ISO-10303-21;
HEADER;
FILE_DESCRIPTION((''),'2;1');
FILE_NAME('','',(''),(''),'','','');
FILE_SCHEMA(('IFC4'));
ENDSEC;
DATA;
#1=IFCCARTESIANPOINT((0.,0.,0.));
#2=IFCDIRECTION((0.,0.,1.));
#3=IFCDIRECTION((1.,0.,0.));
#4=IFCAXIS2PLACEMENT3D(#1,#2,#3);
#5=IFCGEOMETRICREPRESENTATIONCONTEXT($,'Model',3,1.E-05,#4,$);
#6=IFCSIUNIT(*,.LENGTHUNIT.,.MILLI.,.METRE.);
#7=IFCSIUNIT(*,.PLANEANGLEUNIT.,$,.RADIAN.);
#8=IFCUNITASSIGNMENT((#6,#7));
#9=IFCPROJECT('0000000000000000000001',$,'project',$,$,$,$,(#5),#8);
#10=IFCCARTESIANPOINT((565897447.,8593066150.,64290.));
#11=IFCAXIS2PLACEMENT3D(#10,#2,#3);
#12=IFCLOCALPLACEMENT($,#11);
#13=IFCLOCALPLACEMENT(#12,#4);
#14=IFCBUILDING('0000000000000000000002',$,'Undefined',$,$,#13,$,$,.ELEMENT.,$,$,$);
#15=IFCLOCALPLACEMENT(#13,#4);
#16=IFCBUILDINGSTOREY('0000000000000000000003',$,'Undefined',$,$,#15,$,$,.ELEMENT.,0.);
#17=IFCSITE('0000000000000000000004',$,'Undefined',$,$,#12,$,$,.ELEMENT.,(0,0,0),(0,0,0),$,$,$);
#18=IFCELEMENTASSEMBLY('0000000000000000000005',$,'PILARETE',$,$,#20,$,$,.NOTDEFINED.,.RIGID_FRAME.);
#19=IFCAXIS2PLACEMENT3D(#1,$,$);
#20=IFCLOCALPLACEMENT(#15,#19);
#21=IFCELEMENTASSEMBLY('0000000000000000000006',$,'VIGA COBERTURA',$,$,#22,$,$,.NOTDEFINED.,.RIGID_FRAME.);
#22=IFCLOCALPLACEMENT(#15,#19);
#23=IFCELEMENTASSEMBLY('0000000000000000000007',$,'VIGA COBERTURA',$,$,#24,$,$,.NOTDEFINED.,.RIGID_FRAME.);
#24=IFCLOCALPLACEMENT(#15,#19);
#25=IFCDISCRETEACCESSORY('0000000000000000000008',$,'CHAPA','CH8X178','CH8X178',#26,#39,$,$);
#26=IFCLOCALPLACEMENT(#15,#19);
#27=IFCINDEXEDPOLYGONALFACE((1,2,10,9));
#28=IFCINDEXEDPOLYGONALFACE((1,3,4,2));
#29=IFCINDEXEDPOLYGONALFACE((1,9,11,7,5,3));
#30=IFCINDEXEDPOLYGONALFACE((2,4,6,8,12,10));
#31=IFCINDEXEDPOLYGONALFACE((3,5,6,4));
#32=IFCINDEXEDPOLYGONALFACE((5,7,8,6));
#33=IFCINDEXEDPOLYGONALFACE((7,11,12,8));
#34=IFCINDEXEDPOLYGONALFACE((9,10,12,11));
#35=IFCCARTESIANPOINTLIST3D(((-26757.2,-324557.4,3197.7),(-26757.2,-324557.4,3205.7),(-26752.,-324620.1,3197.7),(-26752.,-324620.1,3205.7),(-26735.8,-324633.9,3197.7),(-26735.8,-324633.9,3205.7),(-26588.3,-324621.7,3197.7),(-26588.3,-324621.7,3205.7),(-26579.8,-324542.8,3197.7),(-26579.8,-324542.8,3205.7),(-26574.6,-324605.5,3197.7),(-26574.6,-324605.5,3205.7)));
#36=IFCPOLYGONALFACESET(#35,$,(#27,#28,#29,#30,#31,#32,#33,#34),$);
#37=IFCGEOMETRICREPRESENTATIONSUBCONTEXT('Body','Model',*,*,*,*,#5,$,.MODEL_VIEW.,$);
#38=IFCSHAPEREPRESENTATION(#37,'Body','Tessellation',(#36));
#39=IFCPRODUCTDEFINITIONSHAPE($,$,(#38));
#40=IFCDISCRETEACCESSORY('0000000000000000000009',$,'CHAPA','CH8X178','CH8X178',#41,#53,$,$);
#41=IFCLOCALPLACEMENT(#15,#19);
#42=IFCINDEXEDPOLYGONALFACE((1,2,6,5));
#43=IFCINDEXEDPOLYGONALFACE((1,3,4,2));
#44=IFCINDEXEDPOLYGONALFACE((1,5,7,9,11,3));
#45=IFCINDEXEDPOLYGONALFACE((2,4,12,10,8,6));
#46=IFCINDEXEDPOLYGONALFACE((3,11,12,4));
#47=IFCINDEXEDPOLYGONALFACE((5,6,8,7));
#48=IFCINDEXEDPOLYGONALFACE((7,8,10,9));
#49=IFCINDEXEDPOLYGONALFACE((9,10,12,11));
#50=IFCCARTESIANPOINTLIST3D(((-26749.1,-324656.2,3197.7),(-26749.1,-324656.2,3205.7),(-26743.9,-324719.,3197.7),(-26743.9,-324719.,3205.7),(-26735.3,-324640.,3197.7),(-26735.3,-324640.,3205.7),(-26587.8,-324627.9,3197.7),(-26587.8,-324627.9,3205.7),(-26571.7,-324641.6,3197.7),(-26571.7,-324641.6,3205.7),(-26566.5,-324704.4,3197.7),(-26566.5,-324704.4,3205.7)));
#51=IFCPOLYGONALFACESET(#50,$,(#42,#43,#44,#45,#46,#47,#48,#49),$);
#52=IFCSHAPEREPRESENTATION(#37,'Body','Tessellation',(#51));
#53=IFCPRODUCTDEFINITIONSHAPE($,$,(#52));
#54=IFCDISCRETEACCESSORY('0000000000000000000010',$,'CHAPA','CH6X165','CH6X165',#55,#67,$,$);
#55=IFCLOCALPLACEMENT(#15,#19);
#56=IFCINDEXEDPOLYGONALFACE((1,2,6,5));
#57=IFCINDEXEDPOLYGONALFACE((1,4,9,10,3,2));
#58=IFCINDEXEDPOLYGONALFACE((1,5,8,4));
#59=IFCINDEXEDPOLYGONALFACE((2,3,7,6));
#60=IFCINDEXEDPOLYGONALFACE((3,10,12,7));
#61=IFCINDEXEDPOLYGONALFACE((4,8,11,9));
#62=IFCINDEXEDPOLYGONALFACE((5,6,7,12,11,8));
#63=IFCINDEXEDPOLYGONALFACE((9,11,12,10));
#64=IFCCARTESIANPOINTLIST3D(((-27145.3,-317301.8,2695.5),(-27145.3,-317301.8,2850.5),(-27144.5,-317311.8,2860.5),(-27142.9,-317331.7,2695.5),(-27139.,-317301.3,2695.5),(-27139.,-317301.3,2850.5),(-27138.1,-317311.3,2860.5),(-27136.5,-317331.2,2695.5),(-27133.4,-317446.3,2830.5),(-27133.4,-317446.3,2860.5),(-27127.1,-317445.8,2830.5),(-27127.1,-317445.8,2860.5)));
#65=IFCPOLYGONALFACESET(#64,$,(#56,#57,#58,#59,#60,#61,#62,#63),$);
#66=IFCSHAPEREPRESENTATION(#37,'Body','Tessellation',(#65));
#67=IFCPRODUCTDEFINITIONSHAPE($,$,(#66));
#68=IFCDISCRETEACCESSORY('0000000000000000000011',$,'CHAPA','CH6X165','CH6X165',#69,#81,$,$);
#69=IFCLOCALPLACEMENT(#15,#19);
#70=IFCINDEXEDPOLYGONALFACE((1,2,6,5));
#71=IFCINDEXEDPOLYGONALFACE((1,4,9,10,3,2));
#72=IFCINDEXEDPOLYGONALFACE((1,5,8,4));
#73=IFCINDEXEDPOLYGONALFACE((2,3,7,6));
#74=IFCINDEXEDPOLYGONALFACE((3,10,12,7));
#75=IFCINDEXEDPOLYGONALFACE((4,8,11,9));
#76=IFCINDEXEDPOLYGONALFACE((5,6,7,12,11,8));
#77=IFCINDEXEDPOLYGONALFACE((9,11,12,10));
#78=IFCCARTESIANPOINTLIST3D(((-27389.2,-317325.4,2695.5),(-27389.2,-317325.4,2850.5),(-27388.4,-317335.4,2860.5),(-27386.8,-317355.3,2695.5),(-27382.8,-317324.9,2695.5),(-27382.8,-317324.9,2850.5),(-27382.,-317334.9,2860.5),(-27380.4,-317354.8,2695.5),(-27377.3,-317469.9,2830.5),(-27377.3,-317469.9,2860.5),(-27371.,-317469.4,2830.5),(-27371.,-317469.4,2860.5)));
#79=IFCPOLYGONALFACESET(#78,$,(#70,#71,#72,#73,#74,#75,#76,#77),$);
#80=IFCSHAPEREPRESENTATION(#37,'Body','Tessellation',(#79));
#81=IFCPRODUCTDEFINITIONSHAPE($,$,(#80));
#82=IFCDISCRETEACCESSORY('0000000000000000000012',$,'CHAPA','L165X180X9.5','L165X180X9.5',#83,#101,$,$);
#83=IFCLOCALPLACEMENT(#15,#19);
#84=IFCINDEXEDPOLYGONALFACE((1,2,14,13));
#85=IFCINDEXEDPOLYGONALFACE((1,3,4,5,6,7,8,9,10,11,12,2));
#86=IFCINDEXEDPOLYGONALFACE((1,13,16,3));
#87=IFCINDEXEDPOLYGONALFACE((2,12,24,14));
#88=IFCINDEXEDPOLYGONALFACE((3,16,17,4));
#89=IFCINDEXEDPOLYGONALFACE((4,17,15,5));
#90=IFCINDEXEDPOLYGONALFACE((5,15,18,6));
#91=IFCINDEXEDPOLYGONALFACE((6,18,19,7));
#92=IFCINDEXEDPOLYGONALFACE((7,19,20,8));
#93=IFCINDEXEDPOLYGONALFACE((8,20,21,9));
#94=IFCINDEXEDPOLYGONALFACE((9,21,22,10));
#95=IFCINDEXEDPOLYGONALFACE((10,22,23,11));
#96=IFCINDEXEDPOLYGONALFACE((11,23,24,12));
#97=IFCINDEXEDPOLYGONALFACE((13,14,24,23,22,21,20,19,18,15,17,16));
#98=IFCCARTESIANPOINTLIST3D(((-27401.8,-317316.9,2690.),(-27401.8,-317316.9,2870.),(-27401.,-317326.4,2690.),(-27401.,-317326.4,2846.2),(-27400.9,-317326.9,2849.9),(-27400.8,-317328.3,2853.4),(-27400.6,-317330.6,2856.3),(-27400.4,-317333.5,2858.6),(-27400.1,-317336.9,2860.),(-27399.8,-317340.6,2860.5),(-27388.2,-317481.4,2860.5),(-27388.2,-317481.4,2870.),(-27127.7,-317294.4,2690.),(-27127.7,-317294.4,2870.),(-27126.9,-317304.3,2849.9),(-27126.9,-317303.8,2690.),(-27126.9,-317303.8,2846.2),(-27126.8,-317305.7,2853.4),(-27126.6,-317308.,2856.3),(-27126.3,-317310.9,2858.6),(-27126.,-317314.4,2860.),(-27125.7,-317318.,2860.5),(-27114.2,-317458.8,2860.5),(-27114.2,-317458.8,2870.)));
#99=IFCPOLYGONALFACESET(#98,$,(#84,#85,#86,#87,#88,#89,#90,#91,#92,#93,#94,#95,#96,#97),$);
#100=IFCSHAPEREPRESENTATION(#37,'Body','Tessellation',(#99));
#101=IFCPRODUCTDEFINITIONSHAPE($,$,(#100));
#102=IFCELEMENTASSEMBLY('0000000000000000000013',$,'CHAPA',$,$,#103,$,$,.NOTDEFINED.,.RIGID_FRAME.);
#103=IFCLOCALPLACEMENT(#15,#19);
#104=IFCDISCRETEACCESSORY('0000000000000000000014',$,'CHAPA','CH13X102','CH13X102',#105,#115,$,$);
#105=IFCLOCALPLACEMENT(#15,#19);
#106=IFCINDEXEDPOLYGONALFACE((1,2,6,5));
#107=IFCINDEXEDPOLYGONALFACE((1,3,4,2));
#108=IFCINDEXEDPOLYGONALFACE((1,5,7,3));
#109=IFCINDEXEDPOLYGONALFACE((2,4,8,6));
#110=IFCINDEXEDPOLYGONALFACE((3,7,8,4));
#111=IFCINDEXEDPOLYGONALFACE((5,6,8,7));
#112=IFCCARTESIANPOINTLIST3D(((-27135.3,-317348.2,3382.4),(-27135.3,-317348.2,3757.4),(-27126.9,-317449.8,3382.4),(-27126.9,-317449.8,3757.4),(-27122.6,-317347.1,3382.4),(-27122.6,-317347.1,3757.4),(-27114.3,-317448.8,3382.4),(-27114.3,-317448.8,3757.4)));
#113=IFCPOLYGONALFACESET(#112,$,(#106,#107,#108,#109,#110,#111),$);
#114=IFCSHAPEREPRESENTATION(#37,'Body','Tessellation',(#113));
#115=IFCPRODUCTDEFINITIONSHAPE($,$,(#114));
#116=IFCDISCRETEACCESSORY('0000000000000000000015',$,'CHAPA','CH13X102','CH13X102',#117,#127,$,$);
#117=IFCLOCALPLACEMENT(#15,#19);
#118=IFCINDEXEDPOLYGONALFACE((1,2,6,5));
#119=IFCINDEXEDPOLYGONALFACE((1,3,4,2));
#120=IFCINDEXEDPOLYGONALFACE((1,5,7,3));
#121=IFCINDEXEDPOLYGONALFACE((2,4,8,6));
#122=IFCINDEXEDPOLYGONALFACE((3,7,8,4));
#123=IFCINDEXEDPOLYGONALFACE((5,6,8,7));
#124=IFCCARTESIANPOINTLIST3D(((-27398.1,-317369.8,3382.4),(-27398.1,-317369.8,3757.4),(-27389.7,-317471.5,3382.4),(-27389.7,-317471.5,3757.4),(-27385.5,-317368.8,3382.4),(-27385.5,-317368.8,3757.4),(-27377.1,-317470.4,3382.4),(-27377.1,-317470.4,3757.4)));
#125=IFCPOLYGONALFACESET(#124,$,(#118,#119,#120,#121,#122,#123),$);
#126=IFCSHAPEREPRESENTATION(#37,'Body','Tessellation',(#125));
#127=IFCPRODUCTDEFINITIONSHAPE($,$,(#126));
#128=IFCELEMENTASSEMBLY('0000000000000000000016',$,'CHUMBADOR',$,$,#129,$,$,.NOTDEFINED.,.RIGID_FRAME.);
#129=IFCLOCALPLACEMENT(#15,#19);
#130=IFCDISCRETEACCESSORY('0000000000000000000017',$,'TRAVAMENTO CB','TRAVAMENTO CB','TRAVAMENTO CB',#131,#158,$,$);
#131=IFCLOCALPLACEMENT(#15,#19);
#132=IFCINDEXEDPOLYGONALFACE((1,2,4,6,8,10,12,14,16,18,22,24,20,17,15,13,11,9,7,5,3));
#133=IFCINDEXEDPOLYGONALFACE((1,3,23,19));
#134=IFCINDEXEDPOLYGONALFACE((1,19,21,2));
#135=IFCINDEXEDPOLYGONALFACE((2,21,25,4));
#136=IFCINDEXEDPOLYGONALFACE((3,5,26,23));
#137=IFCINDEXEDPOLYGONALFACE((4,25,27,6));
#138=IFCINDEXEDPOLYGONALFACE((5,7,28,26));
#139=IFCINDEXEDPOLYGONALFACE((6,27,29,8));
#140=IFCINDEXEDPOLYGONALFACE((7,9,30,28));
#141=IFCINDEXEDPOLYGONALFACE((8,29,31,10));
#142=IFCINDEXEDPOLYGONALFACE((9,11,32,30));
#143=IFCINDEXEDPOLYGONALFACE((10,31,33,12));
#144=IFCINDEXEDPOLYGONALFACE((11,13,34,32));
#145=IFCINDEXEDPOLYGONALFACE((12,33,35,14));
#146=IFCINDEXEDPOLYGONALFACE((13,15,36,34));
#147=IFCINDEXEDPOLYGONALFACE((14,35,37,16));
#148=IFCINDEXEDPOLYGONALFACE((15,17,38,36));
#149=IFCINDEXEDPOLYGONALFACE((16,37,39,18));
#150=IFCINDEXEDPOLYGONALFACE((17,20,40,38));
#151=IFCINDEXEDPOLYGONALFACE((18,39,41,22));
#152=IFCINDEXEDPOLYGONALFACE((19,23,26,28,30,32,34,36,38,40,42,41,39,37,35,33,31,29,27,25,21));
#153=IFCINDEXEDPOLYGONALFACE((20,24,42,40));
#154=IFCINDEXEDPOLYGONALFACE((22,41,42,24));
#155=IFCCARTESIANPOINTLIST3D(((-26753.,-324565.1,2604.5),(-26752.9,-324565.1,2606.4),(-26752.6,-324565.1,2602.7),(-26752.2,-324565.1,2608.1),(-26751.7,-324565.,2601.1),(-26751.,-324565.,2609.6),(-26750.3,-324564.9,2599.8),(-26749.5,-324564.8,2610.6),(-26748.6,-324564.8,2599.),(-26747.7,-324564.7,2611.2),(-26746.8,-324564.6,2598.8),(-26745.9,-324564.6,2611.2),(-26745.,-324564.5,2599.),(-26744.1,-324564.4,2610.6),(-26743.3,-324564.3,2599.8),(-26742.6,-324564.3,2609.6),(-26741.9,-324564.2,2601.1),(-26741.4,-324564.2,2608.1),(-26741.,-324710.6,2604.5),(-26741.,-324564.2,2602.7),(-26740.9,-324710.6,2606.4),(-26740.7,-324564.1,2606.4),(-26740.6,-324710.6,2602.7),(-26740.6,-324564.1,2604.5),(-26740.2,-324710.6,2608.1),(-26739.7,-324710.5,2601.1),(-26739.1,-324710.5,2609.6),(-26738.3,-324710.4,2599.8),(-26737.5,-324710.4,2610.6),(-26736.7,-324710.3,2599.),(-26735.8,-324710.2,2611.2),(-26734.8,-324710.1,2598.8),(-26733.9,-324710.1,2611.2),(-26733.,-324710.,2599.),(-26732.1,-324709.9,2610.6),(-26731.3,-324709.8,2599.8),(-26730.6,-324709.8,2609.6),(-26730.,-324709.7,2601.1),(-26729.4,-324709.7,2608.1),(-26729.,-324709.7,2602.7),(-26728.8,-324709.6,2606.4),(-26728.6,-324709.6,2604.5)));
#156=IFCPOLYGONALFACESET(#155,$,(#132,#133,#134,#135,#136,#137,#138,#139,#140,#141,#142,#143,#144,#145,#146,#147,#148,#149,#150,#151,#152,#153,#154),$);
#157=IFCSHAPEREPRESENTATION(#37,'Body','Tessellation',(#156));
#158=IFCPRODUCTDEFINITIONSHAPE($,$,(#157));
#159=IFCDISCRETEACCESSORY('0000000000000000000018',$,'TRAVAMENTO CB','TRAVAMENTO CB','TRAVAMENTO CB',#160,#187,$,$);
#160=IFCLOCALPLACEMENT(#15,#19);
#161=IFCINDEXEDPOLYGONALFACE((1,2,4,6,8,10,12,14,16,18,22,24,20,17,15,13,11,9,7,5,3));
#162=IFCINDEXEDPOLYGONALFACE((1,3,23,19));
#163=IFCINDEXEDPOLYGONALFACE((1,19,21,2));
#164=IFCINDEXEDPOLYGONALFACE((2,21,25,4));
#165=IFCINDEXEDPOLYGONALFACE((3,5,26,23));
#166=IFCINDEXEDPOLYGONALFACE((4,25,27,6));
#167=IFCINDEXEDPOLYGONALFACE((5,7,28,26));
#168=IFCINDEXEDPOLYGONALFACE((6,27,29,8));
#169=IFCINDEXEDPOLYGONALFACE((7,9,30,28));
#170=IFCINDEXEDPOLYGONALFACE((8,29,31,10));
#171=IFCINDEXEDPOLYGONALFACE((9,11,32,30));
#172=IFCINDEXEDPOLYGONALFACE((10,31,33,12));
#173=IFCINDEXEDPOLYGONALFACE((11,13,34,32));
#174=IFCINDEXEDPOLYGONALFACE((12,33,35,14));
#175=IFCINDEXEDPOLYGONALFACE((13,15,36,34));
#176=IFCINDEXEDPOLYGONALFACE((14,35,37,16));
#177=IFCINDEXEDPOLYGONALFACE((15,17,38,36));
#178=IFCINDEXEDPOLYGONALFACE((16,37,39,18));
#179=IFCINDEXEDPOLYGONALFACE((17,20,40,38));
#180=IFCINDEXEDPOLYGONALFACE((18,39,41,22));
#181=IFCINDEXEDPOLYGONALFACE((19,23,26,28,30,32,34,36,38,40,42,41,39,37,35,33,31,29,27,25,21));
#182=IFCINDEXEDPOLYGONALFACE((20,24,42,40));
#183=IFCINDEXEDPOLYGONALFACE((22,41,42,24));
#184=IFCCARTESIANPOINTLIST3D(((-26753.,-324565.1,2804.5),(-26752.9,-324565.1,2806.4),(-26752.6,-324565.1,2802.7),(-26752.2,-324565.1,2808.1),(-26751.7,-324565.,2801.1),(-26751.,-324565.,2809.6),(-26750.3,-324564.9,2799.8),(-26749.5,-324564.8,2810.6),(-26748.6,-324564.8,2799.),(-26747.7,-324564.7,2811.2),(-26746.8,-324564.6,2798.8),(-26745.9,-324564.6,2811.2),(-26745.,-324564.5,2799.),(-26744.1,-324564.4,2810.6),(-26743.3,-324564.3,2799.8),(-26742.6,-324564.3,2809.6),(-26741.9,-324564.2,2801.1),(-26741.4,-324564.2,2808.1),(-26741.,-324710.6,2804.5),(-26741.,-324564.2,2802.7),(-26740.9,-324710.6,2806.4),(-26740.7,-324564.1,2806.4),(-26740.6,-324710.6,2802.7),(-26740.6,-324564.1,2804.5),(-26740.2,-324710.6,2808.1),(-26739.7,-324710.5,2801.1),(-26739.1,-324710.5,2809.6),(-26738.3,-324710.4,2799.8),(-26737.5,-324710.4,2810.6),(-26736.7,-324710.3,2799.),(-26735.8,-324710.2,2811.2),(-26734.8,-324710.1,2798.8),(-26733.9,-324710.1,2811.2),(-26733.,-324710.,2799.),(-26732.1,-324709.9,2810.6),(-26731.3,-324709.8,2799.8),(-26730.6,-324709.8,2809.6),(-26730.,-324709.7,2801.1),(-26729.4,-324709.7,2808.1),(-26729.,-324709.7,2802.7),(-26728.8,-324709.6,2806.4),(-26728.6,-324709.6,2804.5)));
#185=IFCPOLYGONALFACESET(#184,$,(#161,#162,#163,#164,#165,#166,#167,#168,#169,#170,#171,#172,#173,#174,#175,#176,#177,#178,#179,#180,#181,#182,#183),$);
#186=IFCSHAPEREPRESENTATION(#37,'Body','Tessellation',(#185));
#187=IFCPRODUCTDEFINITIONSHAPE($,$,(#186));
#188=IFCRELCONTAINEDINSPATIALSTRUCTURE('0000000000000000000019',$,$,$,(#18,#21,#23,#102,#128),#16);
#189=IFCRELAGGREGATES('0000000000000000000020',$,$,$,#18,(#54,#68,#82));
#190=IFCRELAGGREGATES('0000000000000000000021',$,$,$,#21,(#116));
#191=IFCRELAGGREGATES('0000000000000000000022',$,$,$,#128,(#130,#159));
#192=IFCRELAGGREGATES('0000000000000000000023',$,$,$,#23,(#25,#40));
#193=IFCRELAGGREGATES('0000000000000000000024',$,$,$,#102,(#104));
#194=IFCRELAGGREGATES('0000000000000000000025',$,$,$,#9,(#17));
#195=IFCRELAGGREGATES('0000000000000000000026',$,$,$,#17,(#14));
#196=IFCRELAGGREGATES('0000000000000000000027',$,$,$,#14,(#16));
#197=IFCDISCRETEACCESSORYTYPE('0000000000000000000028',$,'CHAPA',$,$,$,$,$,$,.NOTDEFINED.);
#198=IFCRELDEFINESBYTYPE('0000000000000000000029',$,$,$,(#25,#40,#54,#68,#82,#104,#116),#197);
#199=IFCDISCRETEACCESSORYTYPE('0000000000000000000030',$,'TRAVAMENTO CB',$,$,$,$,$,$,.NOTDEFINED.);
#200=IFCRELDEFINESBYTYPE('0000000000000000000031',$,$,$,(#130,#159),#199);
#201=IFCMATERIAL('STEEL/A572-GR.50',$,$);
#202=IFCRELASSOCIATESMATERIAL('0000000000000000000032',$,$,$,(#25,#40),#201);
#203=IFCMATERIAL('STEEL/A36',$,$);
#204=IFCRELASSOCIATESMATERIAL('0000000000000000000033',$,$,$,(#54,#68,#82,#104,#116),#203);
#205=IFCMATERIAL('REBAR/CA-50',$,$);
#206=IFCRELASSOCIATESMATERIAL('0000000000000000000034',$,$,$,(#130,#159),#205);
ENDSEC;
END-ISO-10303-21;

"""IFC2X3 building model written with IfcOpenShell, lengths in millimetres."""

from ifc_helpers import new_model, si_unit, frame, origin_with_axes, origin_2d_with_axis, place, context, subcontext, project, spatial, polyline, circle, l_section, outline, extrude, material, type_object, element, aggregate, save


model = new_model("IFC2X3")

# Units and contexts
model_context = context("Model", 3, precision=1e-05, world=origin_with_axes())
body_context = subcontext(model_context, "Body", "Model", "MODEL_VIEW")
ifc_project = project(units=[si_unit("LENGTHUNIT", "METRE", prefix="MILLI"), si_unit("PLANEANGLEUNIT", "RADIAN")], contexts=[model_context])

# Site, building, storey
site_placement = place(None, frame((565897447.0, 8593066150.0, 64290.0), z_axis=(0.0, 0.0, 1.0), x_axis=(1.0, 0.0, 0.0)))
site = spatial("IfcSite", under=ifc_project, at=site_placement, Name="Undefined", CompositionType="ELEMENT", RefLatitude=(0, 0, 0), RefLongitude=(0, 0, 0))
building_placement = place(site_placement, origin_with_axes())
building = spatial("IfcBuilding", under=site, at=building_placement, Name="Undefined", CompositionType="ELEMENT")
storey_placement = place(building_placement, origin_with_axes())
storey = spatial("IfcBuildingStorey", under=building, at=storey_placement, Name="Undefined", CompositionType="ELEMENT", Elevation=0.0)

# Element assembly
assembly_1_placement = place(storey_placement, origin_with_axes())
assembly_1 = element("IfcElementAssembly", 1, at=assembly_1_placement, inside=storey, Name="PILARETE", AssemblyPlace="NOTDEFINED", PredefinedType="RIGID_FRAME")
ifc_material_1 = material(Name="STEEL/A572-GR.50")

# Element assembly
ifc_material_2 = material(Name="STEEL/A36")
assembly_2_placement = place(storey_placement, origin_with_axes())
assembly_2 = element("IfcElementAssembly", 2, at=assembly_2_placement, inside=storey, Name="VIGA COBERTURA", AssemblyPlace="NOTDEFINED", PredefinedType="RIGID_FRAME")

# Shared definitions
discrete_accessory_type_1 = type_object("IfcDiscreteAccessoryType", Name="CHAPA")

# Element assembly, discrete accessories
assembly_3_placement = place(storey_placement, origin_with_axes())
assembly_3 = element("IfcElementAssembly", 3, at=assembly_3_placement, inside=storey, Name="VIGA COBERTURA", AssemblyPlace="NOTDEFINED", PredefinedType="RIGID_FRAME")
discrete_accessory_1_placement = place(assembly_3_placement, frame((-26750.8, -324635.1, 3201.7), z_axis=(0.0, 0.0, -1.0), x_axis=(-0.082025, 0.99663, 0.0)))
discrete_accessory_1 = element("IfcDiscreteAccessory", 4, at=discrete_accessory_1_placement, type_object=discrete_accessory_type_1, material=ifc_material_1, Name="CHAPA", Description="CH8X178", ObjectType="CH8X178", context=body_context, shape_type="SweptSolid", body=[
    extrude(outline(polyline([(0.0, 15.0), (15.0, 0.0), (78.0, 0.0), (78.0, 178.0), (15.0, 178.0), (0.0, 163.0), (0.0, 15.0)])), frame((0.0, 0.0, -4.0), z_axis=(0.0, 0.0, 1.0), x_axis=(1.0, 0.0, 0.0)), (0.0, 0.0, 1.0), 8.0),
])
discrete_accessory_2_placement = place(assembly_3_placement, frame((-26750.3, -324641.3, 3201.7), z_axis=(0.0, 0.0, 1.0), x_axis=(0.082025, -0.99663, 0.0)))
discrete_accessory_2 = element("IfcDiscreteAccessory", 5, at=discrete_accessory_2_placement, type_object=discrete_accessory_type_1, material=ifc_material_1, Name="CHAPA", Description="CH8X178", ObjectType="CH8X178", context=body_context, shape_type="SweptSolid", body=[
    extrude(outline(polyline([(0.0, 15.0), (15.0, 0.0), (78.0, 0.0), (78.0, 178.0), (15.0, 178.0), (0.0, 163.0), (0.0, 15.0)])), frame((0.0, 0.0, -4.0), z_axis=(0.0, 0.0, 1.0), x_axis=(1.0, 0.0, 0.0)), (0.0, 0.0, 1.0), 8.0),
])

# Discrete accessories
discrete_accessory_3_placement = place(assembly_1_placement, frame((-27142.1, -317301.6, 2860.5), z_axis=(-0.99663, -0.082025, -0.000004), x_axis=(0.000004, 0.0, -1.0)))
discrete_accessory_3 = element("IfcDiscreteAccessory", 6, at=discrete_accessory_3_placement, type_object=discrete_accessory_type_1, material=ifc_material_2, Name="CHAPA", Description="CH6X165", ObjectType="CH6X165", context=body_context, shape_type="SweptSolid", body=[
    extrude(outline(polyline([(0.0, 10.0), (10.0, 0.0), (165.0, 0.0), (165.0, 30.0), (30.0, 145.0), (0.0, 145.0), (0.0, 10.0)])), frame((0.0, 0.0, -3.2), z_axis=(0.0, 0.0, 1.0), x_axis=(1.0, 0.0, 0.0)), (0.0, 0.0, 1.0), 6.4),
])
discrete_accessory_4_placement = place(assembly_1_placement, frame((-27386.0, -317325.2, 2860.5), z_axis=(-0.99663, -0.082025, 0.000004), x_axis=(-0.000004, 0.0, -1.0)))
discrete_accessory_4 = element("IfcDiscreteAccessory", 7, at=discrete_accessory_4_placement, type_object=discrete_accessory_type_1, material=ifc_material_2, Name="CHAPA", Description="CH6X165", ObjectType="CH6X165", context=body_context, shape_type="SweptSolid", body=[
    extrude(outline(polyline([(0.0, 10.0), (10.0, 0.0), (165.0, 0.0), (165.0, 30.0), (30.0, 145.0), (0.0, 145.0), (0.0, 10.0)])), frame((0.0, 0.0, -3.2), z_axis=(0.0, 0.0, 1.0), x_axis=(1.0, 0.0, 0.0)), (0.0, 0.0, 1.0), 6.4),
])
discrete_accessory_5_placement = place(assembly_1_placement, frame((-27395.0, -317399.1, 2780.0), z_axis=(0.082025, -0.99663, 0.0), x_axis=(0.99663, 0.082025, 0.0)))
discrete_accessory_5 = element("IfcDiscreteAccessory", 8, at=discrete_accessory_5_placement, type_object=discrete_accessory_type_1, material=ifc_material_2, Name="CHAPA", Description="L165X180X9.5", ObjectType="L165X180X9.5", context=body_context, shape_type="SweptSolid", body=[
    extrude(l_section(Depth=165.0, Width=180.0, Thickness=9.5, FilletRadius=14.2, at=origin_2d_with_axis()), frame((275.0, 0.0, 0.0), z_axis=(-1.0, 0.0, 0.0), x_axis=(0.0, -1.0, 0.0)), (0.0, 0.0, 1.0), 275.0),
])
aggregate(assembly_1, [discrete_accessory_3, discrete_accessory_4, discrete_accessory_5])

# Element assembly, discrete accessory
assembly_4_placement = place(storey_placement, origin_with_axes())
assembly_4 = element("IfcElementAssembly", 9, at=assembly_4_placement, inside=storey, Name="CHAPA", AssemblyPlace="NOTDEFINED", PredefinedType="RIGID_FRAME")
discrete_accessory_6_placement = place(assembly_4_placement, frame((-27124.8, -317398.5, 3757.4), z_axis=(0.99663, 0.082025, 0.0), x_axis=(0.0, 0.0, -1.0)))
discrete_accessory_6 = element("IfcDiscreteAccessory", 10, at=discrete_accessory_6_placement, type_object=discrete_accessory_type_1, material=ifc_material_2, Name="CHAPA", Description="CH13X102", ObjectType="CH13X102", context=body_context, shape_type="SweptSolid", body=[
    extrude(outline(polyline([(375.0, 51.0), (375.0, -51.0), (0.0, -51.0), (0.0, 51.0), (375.0, 51.0)])), frame((0.0, 0.0, -6.3), z_axis=(0.0, 0.0, 1.0), x_axis=(1.0, 0.0, 0.0)), (0.0, 0.0, 1.0), 12.7),
])

# Discrete accessory
discrete_accessory_7_placement = place(assembly_2_placement, frame((-27387.6, -317420.1, 3757.4), z_axis=(0.99663, 0.082025, 0.0), x_axis=(0.0, 0.0, -1.0)))
discrete_accessory_7 = element("IfcDiscreteAccessory", 11, at=discrete_accessory_7_placement, type_object=discrete_accessory_type_1, material=ifc_material_2, Name="CHAPA", Description="CH13X102", ObjectType="CH13X102", context=body_context, shape_type="SweptSolid", body=[
    extrude(outline(polyline([(375.0, 51.0), (375.0, -51.0), (0.0, -51.0), (0.0, 51.0), (375.0, 51.0)])), frame((0.0, 0.0, -6.3), z_axis=(0.0, 0.0, 1.0), x_axis=(1.0, 0.0, 0.0)), (0.0, 0.0, 1.0), 12.7),
])
aggregate(assembly_2, [discrete_accessory_7])

# Element assembly, discrete accessories
assembly_5_placement = place(storey_placement, origin_with_axes())
assembly_5 = element("IfcElementAssembly", 12, at=assembly_5_placement, inside=storey, Name="CHUMBADOR", AssemblyPlace="NOTDEFINED", PredefinedType="RIGID_FRAME")
ifc_material_3 = material(Name="REBAR/CA-50")
discrete_accessory_type_2 = type_object("IfcDiscreteAccessoryType", Name="TRAVAMENTO CB")
discrete_accessory_8_placement = place(assembly_5_placement, frame((-26746.8, -324564.6, 2605.0), z_axis=(-0.99663, -0.082025, 0.0), x_axis=(0.082025, -0.99663, 0.0)))
discrete_accessory_8 = element("IfcDiscreteAccessory", 13, at=discrete_accessory_8_placement, type_object=discrete_accessory_type_2, material=ifc_material_3, Name="TRAVAMENTO CB", Description="TRAVAMENTO CB", ObjectType="TRAVAMENTO CB", context=body_context, shape_type="SweptSolid", body=[
    extrude(circle(Radius=6.2, at=origin_2d_with_axis()), frame((146.0, 0.0, 0.0), z_axis=(-1.0, 0.0, 0.0), x_axis=(0.0, -1.0, 0.0)), (0.0, 0.0, 1.0), 146.0),
])
discrete_accessory_9_placement = place(assembly_5_placement, frame((-26746.8, -324564.6, 2805.0), z_axis=(-0.99663, -0.082025, 0.0), x_axis=(0.082025, -0.99663, 0.0)))
discrete_accessory_9 = element("IfcDiscreteAccessory", 14, at=discrete_accessory_9_placement, type_object=discrete_accessory_type_2, material=ifc_material_3, Name="TRAVAMENTO CB", Description="TRAVAMENTO CB", ObjectType="TRAVAMENTO CB", context=body_context, shape_type="SweptSolid", body=[
    extrude(circle(Radius=6.2, at=origin_2d_with_axis()), frame((146.0, 0.0, 0.0), z_axis=(-1.0, 0.0, 0.0), x_axis=(0.0, -1.0, 0.0)), (0.0, 0.0, 1.0), 146.0),
])
aggregate(assembly_5, [discrete_accessory_8, discrete_accessory_9])

aggregate(assembly_3, [discrete_accessory_1, discrete_accessory_2])
aggregate(assembly_4, [discrete_accessory_6])

save(model, "model.ifc")
